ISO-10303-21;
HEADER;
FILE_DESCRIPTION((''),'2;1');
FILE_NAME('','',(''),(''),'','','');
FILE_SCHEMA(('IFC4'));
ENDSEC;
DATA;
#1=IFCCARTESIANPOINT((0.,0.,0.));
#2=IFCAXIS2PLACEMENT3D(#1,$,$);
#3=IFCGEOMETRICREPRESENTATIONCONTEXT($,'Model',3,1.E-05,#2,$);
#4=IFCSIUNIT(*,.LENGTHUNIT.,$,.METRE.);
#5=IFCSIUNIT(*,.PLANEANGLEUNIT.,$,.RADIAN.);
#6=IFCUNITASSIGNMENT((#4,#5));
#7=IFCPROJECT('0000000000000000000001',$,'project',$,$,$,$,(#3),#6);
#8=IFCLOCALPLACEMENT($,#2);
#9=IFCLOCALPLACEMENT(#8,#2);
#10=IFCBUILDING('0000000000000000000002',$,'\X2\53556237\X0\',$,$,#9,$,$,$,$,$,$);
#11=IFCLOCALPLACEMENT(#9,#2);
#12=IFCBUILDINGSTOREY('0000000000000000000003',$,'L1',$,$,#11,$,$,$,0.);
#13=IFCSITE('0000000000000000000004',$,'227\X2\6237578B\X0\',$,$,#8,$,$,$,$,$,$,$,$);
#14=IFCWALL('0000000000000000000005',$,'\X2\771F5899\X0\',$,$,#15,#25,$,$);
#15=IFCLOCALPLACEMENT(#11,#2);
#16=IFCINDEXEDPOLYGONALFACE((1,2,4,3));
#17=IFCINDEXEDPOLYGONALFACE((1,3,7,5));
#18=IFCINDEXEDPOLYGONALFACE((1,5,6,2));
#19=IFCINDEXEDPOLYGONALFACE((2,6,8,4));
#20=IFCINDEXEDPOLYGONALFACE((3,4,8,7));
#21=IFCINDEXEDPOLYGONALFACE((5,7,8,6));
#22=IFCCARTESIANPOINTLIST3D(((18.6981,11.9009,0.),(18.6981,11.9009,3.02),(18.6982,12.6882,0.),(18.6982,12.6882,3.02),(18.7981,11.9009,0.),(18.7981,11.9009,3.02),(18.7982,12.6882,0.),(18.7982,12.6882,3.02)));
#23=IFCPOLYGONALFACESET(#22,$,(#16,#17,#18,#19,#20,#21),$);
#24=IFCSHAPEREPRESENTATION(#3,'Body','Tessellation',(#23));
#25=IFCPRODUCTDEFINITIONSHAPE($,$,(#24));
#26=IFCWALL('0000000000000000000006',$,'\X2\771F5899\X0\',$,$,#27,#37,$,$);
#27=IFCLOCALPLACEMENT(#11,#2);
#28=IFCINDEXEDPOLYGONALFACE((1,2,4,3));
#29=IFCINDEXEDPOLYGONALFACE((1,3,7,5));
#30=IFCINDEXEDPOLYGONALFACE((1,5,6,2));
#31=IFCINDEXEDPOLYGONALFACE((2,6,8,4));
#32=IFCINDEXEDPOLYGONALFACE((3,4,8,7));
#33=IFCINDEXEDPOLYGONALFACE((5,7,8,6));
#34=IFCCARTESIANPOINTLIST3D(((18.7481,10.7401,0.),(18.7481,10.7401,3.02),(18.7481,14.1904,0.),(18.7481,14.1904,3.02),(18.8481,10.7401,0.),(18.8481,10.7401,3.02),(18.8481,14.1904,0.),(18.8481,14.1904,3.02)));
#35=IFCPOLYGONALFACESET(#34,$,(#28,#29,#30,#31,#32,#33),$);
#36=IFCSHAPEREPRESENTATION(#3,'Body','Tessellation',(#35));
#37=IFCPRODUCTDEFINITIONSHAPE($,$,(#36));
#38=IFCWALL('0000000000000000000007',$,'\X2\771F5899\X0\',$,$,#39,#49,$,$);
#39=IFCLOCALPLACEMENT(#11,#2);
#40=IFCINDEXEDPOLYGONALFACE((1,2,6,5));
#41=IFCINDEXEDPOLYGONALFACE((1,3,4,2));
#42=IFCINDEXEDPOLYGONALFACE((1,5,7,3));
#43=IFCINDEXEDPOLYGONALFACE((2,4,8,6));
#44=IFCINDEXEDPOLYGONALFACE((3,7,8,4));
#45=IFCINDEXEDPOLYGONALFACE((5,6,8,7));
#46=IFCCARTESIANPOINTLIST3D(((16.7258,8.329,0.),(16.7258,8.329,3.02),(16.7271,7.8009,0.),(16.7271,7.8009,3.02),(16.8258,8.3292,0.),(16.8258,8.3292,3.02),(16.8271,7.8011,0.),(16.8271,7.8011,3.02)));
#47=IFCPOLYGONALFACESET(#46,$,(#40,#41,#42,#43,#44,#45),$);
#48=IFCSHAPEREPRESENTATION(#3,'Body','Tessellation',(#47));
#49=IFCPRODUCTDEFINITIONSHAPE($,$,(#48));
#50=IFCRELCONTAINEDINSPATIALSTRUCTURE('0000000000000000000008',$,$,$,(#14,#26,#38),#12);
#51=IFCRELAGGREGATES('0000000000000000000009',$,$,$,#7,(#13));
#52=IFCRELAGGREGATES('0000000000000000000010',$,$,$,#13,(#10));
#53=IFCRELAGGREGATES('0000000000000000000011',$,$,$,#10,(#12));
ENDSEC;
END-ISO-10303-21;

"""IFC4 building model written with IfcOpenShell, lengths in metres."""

from ifc_helpers import new_model, si_unit, origin, place, context, project, spatial, polyline, outline, extrude, element, save


model = new_model("IFC4")

# Units and contexts
model_context = context("Model", 3, precision=1e-05, world=origin())
ifc_project = project(units=[si_unit("LENGTHUNIT", "METRE"), si_unit("PLANEANGLEUNIT", "RADIAN")], contexts=[model_context])

# Site, building, storey
site_placement = place(None, origin())
site = spatial("IfcSite", under=ifc_project, at=site_placement, Name="227户型")
building_placement = place(site_placement, origin())
building = spatial("IfcBuilding", under=site, at=building_placement, Name="单户")
storey_placement = place(building_placement, origin())
storey = spatial("IfcBuildingStorey", under=building, at=storey_placement, Name="L1", Elevation=0.0)

# Walls
wall_1_placement = place(storey_placement, origin())
element("IfcWall", 1, at=wall_1_placement, inside=storey, Name="真墙", context=model_context, shape_type="SweptSolid", body=[
    extrude(outline(polyline([(18.7982, 12.6882), (18.7981, 11.9009), (18.6981, 11.9009), (18.6982, 12.6882), (18.7982, 12.6882)])), origin(), (0.0, 0.0, 1.0), 3.02),
])
wall_2_placement = place(storey_placement, origin())
element("IfcWall", 2, at=wall_2_placement, inside=storey, Name="真墙", context=model_context, shape_type="SweptSolid", body=[
    extrude(outline(polyline([(18.7481, 10.7401), (18.7481, 14.1904), (18.8481, 14.1904), (18.8481, 10.7401), (18.7481, 10.7401)])), origin(), (0.0, 0.0, 1.0), 3.02),
])
wall_3_placement = place(storey_placement, origin())
element("IfcWall", 3, at=wall_3_placement, inside=storey, Name="真墙", context=model_context, shape_type="SweptSolid", body=[
    extrude(outline(polyline([(16.7271, 7.8009), (16.7258, 8.329), (16.8258, 8.3292), (16.8271, 7.8011), (16.7271, 7.8009)])), origin(), (0.0, 0.0, 1.0), 3.02),
])

save(model, "model.ifc")
